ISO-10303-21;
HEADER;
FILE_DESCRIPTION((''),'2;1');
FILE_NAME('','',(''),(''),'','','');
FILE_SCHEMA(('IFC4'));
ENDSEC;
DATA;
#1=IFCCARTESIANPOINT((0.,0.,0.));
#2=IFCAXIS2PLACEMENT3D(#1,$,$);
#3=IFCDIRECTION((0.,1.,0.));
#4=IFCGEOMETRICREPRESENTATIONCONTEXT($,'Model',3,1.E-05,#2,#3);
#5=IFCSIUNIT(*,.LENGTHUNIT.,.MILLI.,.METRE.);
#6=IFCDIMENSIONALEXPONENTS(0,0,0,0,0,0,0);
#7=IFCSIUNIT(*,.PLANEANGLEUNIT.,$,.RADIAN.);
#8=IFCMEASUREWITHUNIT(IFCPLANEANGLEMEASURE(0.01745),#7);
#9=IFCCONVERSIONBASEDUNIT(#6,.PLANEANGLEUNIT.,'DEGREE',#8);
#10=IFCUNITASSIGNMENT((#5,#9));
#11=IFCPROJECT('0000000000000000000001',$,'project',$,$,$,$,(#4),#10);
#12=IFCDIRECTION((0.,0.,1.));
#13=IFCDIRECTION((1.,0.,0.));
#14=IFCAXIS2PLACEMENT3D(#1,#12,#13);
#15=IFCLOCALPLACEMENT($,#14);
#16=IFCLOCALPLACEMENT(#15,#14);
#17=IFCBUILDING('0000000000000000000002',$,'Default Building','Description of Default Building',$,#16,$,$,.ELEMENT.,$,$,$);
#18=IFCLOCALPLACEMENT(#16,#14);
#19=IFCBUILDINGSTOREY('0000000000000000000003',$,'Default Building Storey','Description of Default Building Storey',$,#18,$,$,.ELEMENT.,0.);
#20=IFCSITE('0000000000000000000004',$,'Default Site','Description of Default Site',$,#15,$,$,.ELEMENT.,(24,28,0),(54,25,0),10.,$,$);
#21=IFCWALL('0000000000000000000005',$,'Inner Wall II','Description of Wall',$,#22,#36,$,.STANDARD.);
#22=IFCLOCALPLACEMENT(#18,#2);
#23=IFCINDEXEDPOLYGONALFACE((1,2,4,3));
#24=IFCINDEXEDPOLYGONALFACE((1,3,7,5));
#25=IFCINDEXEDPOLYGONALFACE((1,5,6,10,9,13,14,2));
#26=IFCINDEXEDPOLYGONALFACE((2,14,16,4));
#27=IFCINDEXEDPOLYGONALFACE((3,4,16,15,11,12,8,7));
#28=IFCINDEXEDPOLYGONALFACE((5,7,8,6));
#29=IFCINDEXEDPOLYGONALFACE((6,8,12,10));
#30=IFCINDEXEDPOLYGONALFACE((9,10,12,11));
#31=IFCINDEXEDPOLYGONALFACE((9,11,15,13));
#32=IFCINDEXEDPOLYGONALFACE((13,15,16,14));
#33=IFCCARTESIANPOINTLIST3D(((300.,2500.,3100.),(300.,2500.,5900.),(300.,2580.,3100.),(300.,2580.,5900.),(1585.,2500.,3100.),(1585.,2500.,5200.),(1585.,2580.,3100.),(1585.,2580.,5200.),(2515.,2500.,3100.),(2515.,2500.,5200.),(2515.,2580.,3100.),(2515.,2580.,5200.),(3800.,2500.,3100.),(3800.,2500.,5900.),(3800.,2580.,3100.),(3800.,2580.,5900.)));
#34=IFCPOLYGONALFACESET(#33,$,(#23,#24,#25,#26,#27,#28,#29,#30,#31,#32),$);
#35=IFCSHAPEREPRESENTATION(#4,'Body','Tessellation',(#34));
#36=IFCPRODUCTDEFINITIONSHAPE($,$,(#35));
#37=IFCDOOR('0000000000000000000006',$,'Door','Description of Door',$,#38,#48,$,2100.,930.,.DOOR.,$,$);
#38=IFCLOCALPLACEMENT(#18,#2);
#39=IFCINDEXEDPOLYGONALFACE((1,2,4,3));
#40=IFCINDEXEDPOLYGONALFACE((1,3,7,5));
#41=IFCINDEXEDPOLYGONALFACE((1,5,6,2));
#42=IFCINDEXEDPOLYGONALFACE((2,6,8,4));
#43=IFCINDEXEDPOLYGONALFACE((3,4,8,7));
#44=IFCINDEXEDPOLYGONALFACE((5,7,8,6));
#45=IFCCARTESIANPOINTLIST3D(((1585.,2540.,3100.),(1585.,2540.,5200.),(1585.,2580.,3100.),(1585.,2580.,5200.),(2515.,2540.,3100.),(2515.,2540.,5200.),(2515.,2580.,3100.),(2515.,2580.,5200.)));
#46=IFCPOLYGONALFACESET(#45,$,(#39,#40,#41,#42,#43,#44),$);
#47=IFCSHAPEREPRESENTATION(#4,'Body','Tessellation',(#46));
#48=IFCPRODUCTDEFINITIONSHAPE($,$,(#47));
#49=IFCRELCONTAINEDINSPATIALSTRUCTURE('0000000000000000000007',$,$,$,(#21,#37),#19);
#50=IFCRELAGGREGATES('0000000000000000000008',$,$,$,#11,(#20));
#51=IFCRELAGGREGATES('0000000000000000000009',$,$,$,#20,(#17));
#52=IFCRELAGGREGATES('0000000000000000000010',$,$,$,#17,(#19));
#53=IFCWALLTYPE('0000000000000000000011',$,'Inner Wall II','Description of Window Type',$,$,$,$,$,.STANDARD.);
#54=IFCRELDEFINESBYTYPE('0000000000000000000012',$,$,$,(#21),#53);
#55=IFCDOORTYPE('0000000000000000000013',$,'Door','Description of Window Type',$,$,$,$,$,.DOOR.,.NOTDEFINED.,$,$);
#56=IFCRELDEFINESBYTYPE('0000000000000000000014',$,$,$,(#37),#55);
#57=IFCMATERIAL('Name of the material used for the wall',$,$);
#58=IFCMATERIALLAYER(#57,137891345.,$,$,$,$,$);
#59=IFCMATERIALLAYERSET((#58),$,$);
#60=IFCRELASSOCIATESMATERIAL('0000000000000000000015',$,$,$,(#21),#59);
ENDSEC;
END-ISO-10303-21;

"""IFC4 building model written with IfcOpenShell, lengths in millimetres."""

from ifc_helpers import new_model, entity, si_unit, converted_unit, direction, frame, origin, origin_with_axes, place, context, project, spatial, polyline, outline, extrude, material, layer, layer_set, layer_usage, type_object, element, fill, save


model = new_model("IFC4")

# Units and contexts
model_context = context("Model", 3, precision=1e-05, world=origin(), true_north=direction((0.0, 1.0, 0.0)))
ifc_project = project(units=[si_unit("LENGTHUNIT", "METRE", prefix="MILLI"), converted_unit("PLANEANGLEUNIT", "DEGREE", entity("IfcPlaneAngleMeasure", 0.01745), si_unit("PLANEANGLEUNIT", "RADIAN"), dimensions=[0, 0, 0, 0, 0, 0, 0])], contexts=[model_context])

# Site, building, storey
site_placement = place(None, origin_with_axes())
site = spatial("IfcSite", under=ifc_project, at=site_placement, Name="Default Site", Description="Description of Default Site", CompositionType="ELEMENT", RefLatitude=(24, 28, 0), RefLongitude=(54, 25, 0), RefElevation=10.0)
building_placement = place(site_placement, origin_with_axes())
building = spatial("IfcBuilding", under=site, at=building_placement, Name="Default Building", Description="Description of Default Building", CompositionType="ELEMENT")
storey_placement = place(building_placement, origin_with_axes())
storey = spatial("IfcBuildingStorey", under=building, at=storey_placement, Name="Default Building Storey", Description="Description of Default Building Storey", CompositionType="ELEMENT", Elevation=0.0)

# Wall, opening, door
ifc_material_1 = material(Name="Name of the material used for the wall")
ifc_layer_1 = layer(ifc_material_1, 137891345.0)
ifc_layer_set_1 = layer_set([ifc_layer_1])
ifc_layer_usage_1 = layer_usage(ifc_layer_set_1, "AXIS2", "POSITIVE", -68945672.5)
wall_type_1 = type_object("IfcWallType", Name="Inner Wall II", Description="Description of Window Type", PredefinedType="STANDARD")
wall_1_placement = place(storey_placement, frame((3800.0, 2540.0, 3100.0), z_axis=(0.0, 0.0, 1.0), x_axis=(-1.0, 0.0, 0.0)))
wall_1 = element("IfcWall", 1, at=wall_1_placement, inside=storey, type_object=wall_type_1, material=ifc_layer_usage_1, Name="Inner Wall II", Description="Description of Wall", PredefinedType="STANDARD", context=model_context, shape_type="SweptSolid", body=[
    extrude(outline(polyline([(0.0, -40.0), (0.0, 40.0), (3500.0, 40.0), (3500.0, -40.0), (0.0, -40.0)])), origin_with_axes(), (0.0, 0.0, 1.0), 2800.0),
])
opening_1_placement = place(wall_1_placement, frame((1285.0, -40.0, 0.0), z_axis=(0.0, 0.0, 1.0), x_axis=(1.0, 0.0, 0.0)))
opening_1 = element("IfcOpeningElement", 2, at=opening_1_placement, cuts=wall_1, context=model_context, shape_type="SweptSolid", body=[
    extrude(outline(polyline([(0.0, 0.0), (0.0, 80.0), (930.0, 80.0), (930.0, 0.0), (0.0, 0.0)])), origin_with_axes(), (0.0, 0.0, 1.0), 2100.0),
])
door_type_1 = type_object("IfcDoorType", Name="Door", Description="Description of Window Type", PredefinedType="DOOR")
door_1_placement = place(opening_1_placement, origin_with_axes())
door_1 = element("IfcDoor", 3, at=door_1_placement, inside=storey, type_object=door_type_1, Name="Door", Description="Description of Door", OverallHeight=2100.0, OverallWidth=930.0, PredefinedType="DOOR", context=model_context, shape_type="SweptSolid", body=[
    extrude(outline(polyline([(0.0, 0.0), (0.0, 40.0), (930.0, 40.0), (930.0, 0.0), (0.0, 0.0)])), origin_with_axes(), (0.0, 0.0, 1.0), 2100.0),
])
fill(opening_1, door_1)

save(model, "model.ifc")
